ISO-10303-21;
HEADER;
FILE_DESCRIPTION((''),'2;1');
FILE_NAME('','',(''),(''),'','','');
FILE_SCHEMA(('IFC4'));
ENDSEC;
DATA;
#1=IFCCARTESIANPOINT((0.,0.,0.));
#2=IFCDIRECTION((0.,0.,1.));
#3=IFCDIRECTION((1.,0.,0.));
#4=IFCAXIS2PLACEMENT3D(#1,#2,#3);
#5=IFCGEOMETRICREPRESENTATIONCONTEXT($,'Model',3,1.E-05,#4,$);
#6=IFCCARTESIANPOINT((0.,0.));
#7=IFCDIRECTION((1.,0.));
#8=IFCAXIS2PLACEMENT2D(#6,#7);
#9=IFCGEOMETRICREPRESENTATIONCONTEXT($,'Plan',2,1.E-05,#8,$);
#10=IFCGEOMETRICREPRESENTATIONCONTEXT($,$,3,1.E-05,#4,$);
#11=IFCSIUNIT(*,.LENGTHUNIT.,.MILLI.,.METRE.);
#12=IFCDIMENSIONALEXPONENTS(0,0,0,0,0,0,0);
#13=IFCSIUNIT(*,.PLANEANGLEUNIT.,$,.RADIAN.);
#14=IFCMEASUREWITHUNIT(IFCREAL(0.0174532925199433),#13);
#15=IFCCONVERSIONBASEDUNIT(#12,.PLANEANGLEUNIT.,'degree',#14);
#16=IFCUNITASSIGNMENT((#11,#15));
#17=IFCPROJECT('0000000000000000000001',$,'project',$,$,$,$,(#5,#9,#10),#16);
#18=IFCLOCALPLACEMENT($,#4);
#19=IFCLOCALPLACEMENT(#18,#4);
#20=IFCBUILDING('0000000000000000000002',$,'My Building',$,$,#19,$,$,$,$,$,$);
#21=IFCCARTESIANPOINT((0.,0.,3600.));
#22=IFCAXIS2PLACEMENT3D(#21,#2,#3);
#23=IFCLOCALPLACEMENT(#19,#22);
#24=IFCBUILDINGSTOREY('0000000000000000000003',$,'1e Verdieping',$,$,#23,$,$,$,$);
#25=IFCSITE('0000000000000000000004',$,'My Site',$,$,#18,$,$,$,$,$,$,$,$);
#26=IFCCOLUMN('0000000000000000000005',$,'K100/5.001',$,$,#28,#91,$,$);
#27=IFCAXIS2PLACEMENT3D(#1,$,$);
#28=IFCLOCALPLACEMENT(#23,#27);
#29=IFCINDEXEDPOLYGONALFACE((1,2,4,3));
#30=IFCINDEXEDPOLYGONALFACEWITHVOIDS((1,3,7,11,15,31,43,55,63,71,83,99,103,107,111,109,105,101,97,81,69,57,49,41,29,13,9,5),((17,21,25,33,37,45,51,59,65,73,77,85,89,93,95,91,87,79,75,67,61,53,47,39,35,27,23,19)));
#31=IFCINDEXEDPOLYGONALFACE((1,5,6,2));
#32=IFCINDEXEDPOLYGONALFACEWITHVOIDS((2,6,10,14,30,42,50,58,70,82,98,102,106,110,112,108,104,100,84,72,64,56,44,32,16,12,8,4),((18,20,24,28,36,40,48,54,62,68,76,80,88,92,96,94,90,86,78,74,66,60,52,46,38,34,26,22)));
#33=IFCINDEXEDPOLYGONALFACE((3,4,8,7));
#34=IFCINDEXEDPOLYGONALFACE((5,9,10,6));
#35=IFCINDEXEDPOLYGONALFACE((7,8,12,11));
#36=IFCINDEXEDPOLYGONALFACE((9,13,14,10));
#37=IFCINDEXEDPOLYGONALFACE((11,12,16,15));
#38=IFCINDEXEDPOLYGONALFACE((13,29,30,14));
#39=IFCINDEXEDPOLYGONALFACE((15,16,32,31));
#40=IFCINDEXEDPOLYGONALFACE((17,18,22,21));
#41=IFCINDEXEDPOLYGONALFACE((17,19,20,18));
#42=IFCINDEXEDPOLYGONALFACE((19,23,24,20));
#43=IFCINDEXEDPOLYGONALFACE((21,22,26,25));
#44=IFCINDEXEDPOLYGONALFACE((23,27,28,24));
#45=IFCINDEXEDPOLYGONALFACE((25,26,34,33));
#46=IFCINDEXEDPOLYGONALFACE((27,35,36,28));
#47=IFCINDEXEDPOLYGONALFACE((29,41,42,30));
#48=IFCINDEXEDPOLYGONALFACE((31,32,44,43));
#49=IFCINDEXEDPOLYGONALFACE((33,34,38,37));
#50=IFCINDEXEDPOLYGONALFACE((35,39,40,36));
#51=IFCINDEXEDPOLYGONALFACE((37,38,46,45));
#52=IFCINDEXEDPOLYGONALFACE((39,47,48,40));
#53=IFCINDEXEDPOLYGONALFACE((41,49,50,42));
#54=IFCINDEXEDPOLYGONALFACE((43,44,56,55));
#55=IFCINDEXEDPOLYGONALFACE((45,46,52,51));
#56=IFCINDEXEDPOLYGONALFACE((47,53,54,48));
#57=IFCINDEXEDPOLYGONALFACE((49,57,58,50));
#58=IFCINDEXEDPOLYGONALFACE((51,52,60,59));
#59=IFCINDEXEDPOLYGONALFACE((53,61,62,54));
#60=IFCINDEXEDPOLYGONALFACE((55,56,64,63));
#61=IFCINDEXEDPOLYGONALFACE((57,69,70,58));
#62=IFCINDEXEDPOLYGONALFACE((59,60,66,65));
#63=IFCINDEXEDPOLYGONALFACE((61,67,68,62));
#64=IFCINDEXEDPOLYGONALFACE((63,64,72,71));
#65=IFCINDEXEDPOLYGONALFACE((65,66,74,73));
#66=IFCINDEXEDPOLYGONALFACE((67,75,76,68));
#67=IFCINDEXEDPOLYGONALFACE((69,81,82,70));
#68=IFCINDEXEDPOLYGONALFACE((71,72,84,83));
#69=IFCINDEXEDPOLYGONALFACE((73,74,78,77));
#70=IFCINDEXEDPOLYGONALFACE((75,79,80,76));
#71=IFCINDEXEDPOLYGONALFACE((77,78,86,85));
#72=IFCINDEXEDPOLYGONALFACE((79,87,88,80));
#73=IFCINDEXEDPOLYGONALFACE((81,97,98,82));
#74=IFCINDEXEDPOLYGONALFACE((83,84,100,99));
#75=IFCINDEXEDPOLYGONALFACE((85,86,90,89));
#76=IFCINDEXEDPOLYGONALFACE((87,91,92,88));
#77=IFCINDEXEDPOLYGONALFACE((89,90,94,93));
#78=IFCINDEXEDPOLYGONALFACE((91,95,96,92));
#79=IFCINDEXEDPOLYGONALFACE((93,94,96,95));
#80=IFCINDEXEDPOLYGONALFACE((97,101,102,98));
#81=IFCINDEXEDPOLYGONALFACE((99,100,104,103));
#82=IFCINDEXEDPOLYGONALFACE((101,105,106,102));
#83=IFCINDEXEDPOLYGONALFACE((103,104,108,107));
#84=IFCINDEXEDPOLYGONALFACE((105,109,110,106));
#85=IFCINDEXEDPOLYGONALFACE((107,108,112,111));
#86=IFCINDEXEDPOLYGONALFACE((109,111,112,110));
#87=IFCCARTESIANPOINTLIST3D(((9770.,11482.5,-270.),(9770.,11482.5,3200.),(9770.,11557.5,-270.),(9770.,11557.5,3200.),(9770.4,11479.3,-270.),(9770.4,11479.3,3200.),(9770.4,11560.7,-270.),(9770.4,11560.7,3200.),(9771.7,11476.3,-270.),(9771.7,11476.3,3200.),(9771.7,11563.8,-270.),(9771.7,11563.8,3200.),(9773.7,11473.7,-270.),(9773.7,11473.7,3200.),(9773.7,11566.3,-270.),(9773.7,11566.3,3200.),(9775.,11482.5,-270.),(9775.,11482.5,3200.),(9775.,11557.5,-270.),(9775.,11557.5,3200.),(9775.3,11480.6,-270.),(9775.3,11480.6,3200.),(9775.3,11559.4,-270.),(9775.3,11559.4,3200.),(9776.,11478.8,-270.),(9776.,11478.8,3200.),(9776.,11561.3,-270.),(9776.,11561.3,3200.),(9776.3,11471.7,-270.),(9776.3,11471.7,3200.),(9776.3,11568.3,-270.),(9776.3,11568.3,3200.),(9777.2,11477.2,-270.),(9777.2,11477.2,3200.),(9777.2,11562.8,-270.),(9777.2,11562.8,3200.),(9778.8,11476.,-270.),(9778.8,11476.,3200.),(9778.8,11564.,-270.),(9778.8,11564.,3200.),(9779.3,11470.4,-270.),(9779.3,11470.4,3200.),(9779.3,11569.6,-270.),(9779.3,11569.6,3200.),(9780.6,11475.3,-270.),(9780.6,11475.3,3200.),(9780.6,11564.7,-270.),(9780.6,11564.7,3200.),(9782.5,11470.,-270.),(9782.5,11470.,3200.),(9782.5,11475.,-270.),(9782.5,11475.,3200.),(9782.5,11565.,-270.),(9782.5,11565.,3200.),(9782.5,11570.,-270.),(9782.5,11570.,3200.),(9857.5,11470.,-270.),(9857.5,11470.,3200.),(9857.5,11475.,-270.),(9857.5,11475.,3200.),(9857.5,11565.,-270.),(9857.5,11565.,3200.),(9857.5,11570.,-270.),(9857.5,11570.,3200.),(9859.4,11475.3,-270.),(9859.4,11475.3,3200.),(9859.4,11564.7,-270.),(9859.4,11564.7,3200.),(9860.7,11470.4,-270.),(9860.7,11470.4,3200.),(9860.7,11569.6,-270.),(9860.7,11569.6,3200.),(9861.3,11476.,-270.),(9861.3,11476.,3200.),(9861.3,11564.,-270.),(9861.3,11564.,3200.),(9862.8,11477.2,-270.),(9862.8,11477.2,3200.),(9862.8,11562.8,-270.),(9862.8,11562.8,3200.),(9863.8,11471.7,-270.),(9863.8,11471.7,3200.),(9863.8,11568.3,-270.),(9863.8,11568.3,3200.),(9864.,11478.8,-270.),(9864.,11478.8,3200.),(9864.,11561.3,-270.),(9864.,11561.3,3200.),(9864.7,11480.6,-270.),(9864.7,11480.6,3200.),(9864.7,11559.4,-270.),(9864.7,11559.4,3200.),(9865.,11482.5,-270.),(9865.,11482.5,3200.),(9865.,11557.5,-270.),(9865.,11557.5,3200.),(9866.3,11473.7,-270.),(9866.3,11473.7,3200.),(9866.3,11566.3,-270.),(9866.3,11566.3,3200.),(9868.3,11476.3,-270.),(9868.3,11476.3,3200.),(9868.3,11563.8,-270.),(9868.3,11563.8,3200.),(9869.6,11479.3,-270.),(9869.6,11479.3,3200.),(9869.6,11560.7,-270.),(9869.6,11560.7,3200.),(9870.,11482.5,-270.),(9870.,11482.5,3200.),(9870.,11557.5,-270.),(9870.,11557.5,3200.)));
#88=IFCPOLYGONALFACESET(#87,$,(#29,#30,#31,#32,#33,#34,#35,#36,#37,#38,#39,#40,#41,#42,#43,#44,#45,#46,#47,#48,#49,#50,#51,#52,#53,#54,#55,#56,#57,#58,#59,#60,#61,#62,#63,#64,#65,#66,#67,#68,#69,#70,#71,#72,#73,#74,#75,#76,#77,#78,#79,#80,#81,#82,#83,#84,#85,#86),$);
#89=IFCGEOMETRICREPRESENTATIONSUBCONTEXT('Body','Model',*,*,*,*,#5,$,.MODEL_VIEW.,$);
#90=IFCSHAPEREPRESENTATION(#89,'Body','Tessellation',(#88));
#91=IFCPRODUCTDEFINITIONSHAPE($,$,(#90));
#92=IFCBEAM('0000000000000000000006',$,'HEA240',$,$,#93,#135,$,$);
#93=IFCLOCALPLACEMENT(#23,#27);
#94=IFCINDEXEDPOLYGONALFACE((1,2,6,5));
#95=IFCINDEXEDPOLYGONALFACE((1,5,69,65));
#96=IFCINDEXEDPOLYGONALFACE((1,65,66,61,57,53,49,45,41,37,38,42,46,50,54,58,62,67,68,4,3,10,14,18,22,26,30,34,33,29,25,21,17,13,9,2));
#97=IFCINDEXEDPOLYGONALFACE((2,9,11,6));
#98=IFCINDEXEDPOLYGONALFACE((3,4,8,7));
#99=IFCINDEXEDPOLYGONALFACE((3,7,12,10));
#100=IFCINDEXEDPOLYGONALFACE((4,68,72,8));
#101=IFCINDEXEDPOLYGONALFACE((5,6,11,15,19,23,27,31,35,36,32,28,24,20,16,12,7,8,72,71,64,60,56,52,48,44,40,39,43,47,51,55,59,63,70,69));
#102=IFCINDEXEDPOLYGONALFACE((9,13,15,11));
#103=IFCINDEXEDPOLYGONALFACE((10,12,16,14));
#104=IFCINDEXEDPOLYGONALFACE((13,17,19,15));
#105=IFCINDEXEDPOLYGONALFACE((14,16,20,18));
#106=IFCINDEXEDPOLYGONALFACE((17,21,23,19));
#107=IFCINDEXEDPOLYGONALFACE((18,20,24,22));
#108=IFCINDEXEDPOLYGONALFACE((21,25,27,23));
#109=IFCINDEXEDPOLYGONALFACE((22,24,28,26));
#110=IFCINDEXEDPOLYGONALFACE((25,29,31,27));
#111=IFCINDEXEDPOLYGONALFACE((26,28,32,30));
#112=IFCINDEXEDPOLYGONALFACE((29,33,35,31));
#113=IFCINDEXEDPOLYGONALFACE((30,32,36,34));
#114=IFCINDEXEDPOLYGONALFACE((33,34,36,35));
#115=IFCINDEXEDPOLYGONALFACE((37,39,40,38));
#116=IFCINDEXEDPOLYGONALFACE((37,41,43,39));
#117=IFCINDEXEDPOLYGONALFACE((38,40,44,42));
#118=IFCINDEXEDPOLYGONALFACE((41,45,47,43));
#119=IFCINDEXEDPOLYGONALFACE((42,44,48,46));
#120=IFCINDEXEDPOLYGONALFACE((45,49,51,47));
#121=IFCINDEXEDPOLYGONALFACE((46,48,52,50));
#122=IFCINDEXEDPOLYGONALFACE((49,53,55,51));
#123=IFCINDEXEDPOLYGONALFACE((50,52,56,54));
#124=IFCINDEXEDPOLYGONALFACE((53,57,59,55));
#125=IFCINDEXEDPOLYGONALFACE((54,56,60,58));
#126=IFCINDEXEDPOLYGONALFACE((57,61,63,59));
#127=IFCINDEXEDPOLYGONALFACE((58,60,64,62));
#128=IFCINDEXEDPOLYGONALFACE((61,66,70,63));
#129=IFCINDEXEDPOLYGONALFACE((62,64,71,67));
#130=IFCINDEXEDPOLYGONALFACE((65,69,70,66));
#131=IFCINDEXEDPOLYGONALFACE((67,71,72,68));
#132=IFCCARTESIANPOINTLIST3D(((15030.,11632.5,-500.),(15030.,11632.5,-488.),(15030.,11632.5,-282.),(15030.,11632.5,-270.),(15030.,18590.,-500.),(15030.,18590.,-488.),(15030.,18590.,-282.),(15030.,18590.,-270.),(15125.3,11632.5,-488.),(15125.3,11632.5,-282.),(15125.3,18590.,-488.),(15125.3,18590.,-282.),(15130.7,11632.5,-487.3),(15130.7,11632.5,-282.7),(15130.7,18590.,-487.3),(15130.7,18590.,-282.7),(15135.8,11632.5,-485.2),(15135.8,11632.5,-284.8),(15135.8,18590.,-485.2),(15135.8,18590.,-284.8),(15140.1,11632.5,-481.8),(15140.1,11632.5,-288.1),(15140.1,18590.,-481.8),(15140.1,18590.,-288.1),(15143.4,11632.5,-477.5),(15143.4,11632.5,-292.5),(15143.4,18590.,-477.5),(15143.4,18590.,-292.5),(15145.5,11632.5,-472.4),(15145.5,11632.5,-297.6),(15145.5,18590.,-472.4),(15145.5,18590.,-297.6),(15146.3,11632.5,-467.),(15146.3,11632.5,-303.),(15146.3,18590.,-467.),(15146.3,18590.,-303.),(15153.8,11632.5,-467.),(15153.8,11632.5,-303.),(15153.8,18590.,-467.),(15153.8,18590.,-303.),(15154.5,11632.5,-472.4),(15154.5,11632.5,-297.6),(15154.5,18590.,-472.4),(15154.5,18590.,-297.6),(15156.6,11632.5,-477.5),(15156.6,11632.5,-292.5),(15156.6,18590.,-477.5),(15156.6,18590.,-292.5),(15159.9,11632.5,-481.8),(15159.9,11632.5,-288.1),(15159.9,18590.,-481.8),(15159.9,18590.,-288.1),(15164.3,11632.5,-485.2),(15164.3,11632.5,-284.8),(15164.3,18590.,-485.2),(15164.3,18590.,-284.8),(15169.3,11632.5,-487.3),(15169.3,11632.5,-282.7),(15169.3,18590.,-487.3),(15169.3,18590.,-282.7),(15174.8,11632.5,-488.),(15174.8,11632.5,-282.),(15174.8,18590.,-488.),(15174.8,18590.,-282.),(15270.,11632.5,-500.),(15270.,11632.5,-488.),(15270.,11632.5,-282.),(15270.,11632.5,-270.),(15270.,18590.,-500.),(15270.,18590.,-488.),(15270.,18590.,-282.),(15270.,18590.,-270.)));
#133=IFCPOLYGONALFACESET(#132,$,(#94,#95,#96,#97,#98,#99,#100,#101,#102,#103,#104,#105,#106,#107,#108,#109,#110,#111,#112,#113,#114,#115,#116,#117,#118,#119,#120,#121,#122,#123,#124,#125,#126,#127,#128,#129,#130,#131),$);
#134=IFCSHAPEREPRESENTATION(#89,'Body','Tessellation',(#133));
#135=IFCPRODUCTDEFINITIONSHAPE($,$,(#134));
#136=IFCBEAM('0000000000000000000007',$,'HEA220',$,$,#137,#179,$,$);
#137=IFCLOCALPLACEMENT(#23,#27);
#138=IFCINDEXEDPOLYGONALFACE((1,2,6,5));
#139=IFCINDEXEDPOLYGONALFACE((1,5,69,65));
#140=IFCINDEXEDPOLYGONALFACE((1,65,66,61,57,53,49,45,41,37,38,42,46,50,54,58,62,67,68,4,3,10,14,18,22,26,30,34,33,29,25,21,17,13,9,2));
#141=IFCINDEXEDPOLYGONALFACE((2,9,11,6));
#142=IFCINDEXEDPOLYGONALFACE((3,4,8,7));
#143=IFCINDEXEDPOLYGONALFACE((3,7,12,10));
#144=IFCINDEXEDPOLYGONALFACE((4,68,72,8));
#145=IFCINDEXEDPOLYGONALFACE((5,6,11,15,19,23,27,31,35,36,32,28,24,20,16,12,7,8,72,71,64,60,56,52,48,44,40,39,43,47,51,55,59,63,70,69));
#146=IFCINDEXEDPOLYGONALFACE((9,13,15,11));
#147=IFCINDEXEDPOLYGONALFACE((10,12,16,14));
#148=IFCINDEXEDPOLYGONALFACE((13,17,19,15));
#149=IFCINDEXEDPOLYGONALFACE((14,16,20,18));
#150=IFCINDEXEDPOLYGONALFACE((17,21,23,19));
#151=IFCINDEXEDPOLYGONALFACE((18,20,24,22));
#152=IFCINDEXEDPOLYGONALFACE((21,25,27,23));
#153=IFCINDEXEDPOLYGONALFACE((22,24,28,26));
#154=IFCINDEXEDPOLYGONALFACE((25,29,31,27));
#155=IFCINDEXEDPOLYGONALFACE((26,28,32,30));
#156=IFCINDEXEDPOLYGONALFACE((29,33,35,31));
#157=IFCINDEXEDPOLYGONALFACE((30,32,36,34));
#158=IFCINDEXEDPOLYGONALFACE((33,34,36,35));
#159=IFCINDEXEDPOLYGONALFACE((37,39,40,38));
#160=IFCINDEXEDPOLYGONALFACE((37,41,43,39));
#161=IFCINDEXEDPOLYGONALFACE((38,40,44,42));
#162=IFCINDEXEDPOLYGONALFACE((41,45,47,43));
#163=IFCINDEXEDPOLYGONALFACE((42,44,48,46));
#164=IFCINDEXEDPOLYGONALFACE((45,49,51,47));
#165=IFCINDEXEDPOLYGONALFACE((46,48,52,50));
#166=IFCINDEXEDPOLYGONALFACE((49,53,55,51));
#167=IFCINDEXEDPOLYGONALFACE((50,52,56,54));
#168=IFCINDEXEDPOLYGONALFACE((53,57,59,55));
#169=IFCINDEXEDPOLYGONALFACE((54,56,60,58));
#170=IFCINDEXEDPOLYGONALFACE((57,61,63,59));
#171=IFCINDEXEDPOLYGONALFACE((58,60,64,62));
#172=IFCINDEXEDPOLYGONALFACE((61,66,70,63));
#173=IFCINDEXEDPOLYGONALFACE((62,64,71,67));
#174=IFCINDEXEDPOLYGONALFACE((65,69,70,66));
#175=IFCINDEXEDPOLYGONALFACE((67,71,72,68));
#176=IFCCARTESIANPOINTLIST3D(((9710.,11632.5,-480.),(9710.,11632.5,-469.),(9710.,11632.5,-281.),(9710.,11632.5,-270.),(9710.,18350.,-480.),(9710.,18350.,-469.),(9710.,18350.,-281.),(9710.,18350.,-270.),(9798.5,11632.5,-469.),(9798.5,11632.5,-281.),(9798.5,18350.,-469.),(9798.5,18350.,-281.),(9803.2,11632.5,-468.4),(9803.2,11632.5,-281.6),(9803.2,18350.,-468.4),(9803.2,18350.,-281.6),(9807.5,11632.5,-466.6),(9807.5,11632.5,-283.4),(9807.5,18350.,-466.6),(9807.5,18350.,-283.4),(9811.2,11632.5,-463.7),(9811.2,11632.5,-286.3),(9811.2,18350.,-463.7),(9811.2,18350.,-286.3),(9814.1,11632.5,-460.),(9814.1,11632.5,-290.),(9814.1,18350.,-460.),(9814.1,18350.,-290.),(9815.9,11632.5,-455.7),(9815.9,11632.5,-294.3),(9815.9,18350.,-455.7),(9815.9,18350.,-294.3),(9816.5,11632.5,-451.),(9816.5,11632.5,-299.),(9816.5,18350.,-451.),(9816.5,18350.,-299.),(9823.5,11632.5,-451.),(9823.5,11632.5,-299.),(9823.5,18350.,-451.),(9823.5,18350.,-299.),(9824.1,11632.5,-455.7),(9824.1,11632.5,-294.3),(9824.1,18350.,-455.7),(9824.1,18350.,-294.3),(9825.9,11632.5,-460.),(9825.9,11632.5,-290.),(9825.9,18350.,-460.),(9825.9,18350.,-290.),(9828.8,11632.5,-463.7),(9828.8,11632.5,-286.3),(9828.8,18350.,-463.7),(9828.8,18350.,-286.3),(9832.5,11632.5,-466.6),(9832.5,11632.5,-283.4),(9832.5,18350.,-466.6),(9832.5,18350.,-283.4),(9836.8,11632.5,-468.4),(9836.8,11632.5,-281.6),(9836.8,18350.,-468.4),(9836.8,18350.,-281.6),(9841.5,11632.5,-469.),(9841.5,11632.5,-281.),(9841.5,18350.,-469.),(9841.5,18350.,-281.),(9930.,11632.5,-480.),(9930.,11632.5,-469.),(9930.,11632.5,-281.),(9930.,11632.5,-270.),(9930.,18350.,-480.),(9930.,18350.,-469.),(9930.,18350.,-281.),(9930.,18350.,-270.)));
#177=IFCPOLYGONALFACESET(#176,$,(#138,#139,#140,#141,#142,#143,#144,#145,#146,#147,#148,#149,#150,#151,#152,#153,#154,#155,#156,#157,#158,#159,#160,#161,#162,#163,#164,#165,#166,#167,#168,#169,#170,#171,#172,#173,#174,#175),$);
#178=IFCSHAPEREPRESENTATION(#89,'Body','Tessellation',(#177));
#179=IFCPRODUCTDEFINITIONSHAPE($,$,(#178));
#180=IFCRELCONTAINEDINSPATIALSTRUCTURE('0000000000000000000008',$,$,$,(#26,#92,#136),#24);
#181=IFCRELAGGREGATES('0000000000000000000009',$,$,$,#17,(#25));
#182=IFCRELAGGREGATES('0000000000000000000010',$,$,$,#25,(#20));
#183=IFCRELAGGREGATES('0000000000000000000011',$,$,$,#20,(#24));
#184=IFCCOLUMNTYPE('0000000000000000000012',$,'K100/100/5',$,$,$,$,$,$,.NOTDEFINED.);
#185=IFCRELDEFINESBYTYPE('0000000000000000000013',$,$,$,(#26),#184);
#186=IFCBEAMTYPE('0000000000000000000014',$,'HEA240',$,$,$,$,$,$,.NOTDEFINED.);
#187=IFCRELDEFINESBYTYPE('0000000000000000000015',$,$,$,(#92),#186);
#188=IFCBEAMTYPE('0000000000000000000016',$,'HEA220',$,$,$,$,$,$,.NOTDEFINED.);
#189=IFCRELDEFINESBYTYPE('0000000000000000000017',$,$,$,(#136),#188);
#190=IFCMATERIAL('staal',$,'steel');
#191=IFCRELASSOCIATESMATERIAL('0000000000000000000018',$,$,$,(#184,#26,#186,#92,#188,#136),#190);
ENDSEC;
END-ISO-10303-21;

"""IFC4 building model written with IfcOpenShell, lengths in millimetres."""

from ifc_helpers import new_model, entity, si_unit, converted_unit, frame, origin_with_axes, origin_2d_with_axis, place, context, subcontext, project, spatial, hollow_rectangle, i_section, extrude, material, material_profile, profile_set, profile_usage, type_object, element, save


model = new_model("IFC4")

# Units and contexts
model_context = context("Model", 3, precision=1e-05, world=origin_with_axes())
plan_context = context("Plan", 2, precision=1e-05, world=origin_2d_with_axis())
context_of_model = context(None, 3, precision=1e-05, world=origin_with_axes())
body_context = subcontext(model_context, "Body", "Model", "MODEL_VIEW")
ifc_project = project(units=[si_unit("LENGTHUNIT", "METRE", prefix="MILLI"), converted_unit("PLANEANGLEUNIT", "degree", entity("IfcReal", 0.0174532925199433), si_unit("PLANEANGLEUNIT", "RADIAN"), dimensions=[0, 0, 0, 0, 0, 0, 0])], contexts=[model_context, plan_context, context_of_model])

# Site, building, storey
site_placement = place(None, origin_with_axes())
site = spatial("IfcSite", under=ifc_project, at=site_placement, Name="My Site")
building_placement = place(site_placement, origin_with_axes())
building = spatial("IfcBuilding", under=site, at=building_placement, Name="My Building")
storey_placement = place(building_placement, frame((0.0, 0.0, 3600.0), z_axis=(0.0, 0.0, 1.0), x_axis=(1.0, 0.0, 0.0)))
storey = spatial("IfcBuildingStorey", under=building, at=storey_placement, Name="1e Verdieping")

# Column
ifc_material = material(Name="staal", Category="steel")
ifc_material_profile_1 = material_profile(ifc_material, hollow_rectangle(XDim=100.0, YDim=100.0, WallThickness=5.0, InnerFilletRadius=7.5, OuterFilletRadius=12.5))
ifc_profile_set_1 = profile_set([ifc_material_profile_1], Name="K100/100/5")
column_type_1 = type_object("IfcColumnType", Name="K100/100/5", PredefinedType="NOTDEFINED", material=ifc_profile_set_1)
ifc_profile_usage_1 = profile_usage(ifc_profile_set_1, cardinal=5)
column_1_placement = place(storey_placement, frame((9820.0, 11520.0, -270.0), z_axis=(0.0, 0.0, 1.0), x_axis=(1.0, 0.0, 0.0)))
element("IfcColumn", 1, at=column_1_placement, inside=storey, type_object=column_type_1, material=ifc_profile_usage_1, Name="K100/5.001", context=body_context, shape_type="SweptSolid", body=[
    extrude(hollow_rectangle(XDim=100.0, YDim=100.0, WallThickness=5.0, InnerFilletRadius=7.5, OuterFilletRadius=12.5), origin_with_axes(), (0.0, 0.0, 1.0), 3470.0),
])

# Beams
ifc_material_profile_2 = material_profile(ifc_material, i_section(OverallWidth=240.0, OverallDepth=230.0, WebThickness=7.5, FlangeThickness=12.0, FilletRadius=21.0))
ifc_profile_set_2 = profile_set([ifc_material_profile_2], Name="HEA240")
ifc_profile_usage_2 = profile_usage(ifc_profile_set_2, cardinal=5)
beam_type_1 = type_object("IfcBeamType", Name="HEA240", PredefinedType="NOTDEFINED", material=ifc_profile_set_2)
beam_1_placement = place(storey_placement, frame((15150.0, 18590.0, -385.0), z_axis=(0.0, -1.0, 0.0), x_axis=(1.0, 0.0, 0.0)))
element("IfcBeam", 2, at=beam_1_placement, inside=storey, type_object=beam_type_1, material=ifc_profile_usage_2, Name="HEA240", context=body_context, shape_type="SweptSolid", body=[
    extrude(i_section(OverallWidth=240.0, OverallDepth=230.0, WebThickness=7.5, FlangeThickness=12.0, FilletRadius=21.0), origin_with_axes(), (0.0, 0.0, 1.0), 6957.5),
])
ifc_material_profile_3 = material_profile(ifc_material, i_section(OverallWidth=220.0, OverallDepth=210.0, WebThickness=7.0, FlangeThickness=11.0, FilletRadius=18.0))
ifc_profile_set_3 = profile_set([ifc_material_profile_3], Name="HEA220")
ifc_profile_usage_3 = profile_usage(ifc_profile_set_3)
beam_type_2 = type_object("IfcBeamType", Name="HEA220", PredefinedType="NOTDEFINED", material=ifc_profile_set_3)
beam_2_placement = place(storey_placement, frame((9820.0, 18350.0, -375.0), z_axis=(0.0, -1.0, 0.0), x_axis=(1.0, 0.0, 0.0)))
element("IfcBeam", 3, at=beam_2_placement, inside=storey, type_object=beam_type_2, material=ifc_profile_usage_3, Name="HEA220", context=body_context, shape_type="SweptSolid", body=[
    extrude(i_section(OverallWidth=220.0, OverallDepth=210.0, WebThickness=7.0, FlangeThickness=11.0, FilletRadius=18.0), origin_with_axes(), (0.0, 0.0, 1.0), 6717.5),
])

save(model, "model.ifc")
